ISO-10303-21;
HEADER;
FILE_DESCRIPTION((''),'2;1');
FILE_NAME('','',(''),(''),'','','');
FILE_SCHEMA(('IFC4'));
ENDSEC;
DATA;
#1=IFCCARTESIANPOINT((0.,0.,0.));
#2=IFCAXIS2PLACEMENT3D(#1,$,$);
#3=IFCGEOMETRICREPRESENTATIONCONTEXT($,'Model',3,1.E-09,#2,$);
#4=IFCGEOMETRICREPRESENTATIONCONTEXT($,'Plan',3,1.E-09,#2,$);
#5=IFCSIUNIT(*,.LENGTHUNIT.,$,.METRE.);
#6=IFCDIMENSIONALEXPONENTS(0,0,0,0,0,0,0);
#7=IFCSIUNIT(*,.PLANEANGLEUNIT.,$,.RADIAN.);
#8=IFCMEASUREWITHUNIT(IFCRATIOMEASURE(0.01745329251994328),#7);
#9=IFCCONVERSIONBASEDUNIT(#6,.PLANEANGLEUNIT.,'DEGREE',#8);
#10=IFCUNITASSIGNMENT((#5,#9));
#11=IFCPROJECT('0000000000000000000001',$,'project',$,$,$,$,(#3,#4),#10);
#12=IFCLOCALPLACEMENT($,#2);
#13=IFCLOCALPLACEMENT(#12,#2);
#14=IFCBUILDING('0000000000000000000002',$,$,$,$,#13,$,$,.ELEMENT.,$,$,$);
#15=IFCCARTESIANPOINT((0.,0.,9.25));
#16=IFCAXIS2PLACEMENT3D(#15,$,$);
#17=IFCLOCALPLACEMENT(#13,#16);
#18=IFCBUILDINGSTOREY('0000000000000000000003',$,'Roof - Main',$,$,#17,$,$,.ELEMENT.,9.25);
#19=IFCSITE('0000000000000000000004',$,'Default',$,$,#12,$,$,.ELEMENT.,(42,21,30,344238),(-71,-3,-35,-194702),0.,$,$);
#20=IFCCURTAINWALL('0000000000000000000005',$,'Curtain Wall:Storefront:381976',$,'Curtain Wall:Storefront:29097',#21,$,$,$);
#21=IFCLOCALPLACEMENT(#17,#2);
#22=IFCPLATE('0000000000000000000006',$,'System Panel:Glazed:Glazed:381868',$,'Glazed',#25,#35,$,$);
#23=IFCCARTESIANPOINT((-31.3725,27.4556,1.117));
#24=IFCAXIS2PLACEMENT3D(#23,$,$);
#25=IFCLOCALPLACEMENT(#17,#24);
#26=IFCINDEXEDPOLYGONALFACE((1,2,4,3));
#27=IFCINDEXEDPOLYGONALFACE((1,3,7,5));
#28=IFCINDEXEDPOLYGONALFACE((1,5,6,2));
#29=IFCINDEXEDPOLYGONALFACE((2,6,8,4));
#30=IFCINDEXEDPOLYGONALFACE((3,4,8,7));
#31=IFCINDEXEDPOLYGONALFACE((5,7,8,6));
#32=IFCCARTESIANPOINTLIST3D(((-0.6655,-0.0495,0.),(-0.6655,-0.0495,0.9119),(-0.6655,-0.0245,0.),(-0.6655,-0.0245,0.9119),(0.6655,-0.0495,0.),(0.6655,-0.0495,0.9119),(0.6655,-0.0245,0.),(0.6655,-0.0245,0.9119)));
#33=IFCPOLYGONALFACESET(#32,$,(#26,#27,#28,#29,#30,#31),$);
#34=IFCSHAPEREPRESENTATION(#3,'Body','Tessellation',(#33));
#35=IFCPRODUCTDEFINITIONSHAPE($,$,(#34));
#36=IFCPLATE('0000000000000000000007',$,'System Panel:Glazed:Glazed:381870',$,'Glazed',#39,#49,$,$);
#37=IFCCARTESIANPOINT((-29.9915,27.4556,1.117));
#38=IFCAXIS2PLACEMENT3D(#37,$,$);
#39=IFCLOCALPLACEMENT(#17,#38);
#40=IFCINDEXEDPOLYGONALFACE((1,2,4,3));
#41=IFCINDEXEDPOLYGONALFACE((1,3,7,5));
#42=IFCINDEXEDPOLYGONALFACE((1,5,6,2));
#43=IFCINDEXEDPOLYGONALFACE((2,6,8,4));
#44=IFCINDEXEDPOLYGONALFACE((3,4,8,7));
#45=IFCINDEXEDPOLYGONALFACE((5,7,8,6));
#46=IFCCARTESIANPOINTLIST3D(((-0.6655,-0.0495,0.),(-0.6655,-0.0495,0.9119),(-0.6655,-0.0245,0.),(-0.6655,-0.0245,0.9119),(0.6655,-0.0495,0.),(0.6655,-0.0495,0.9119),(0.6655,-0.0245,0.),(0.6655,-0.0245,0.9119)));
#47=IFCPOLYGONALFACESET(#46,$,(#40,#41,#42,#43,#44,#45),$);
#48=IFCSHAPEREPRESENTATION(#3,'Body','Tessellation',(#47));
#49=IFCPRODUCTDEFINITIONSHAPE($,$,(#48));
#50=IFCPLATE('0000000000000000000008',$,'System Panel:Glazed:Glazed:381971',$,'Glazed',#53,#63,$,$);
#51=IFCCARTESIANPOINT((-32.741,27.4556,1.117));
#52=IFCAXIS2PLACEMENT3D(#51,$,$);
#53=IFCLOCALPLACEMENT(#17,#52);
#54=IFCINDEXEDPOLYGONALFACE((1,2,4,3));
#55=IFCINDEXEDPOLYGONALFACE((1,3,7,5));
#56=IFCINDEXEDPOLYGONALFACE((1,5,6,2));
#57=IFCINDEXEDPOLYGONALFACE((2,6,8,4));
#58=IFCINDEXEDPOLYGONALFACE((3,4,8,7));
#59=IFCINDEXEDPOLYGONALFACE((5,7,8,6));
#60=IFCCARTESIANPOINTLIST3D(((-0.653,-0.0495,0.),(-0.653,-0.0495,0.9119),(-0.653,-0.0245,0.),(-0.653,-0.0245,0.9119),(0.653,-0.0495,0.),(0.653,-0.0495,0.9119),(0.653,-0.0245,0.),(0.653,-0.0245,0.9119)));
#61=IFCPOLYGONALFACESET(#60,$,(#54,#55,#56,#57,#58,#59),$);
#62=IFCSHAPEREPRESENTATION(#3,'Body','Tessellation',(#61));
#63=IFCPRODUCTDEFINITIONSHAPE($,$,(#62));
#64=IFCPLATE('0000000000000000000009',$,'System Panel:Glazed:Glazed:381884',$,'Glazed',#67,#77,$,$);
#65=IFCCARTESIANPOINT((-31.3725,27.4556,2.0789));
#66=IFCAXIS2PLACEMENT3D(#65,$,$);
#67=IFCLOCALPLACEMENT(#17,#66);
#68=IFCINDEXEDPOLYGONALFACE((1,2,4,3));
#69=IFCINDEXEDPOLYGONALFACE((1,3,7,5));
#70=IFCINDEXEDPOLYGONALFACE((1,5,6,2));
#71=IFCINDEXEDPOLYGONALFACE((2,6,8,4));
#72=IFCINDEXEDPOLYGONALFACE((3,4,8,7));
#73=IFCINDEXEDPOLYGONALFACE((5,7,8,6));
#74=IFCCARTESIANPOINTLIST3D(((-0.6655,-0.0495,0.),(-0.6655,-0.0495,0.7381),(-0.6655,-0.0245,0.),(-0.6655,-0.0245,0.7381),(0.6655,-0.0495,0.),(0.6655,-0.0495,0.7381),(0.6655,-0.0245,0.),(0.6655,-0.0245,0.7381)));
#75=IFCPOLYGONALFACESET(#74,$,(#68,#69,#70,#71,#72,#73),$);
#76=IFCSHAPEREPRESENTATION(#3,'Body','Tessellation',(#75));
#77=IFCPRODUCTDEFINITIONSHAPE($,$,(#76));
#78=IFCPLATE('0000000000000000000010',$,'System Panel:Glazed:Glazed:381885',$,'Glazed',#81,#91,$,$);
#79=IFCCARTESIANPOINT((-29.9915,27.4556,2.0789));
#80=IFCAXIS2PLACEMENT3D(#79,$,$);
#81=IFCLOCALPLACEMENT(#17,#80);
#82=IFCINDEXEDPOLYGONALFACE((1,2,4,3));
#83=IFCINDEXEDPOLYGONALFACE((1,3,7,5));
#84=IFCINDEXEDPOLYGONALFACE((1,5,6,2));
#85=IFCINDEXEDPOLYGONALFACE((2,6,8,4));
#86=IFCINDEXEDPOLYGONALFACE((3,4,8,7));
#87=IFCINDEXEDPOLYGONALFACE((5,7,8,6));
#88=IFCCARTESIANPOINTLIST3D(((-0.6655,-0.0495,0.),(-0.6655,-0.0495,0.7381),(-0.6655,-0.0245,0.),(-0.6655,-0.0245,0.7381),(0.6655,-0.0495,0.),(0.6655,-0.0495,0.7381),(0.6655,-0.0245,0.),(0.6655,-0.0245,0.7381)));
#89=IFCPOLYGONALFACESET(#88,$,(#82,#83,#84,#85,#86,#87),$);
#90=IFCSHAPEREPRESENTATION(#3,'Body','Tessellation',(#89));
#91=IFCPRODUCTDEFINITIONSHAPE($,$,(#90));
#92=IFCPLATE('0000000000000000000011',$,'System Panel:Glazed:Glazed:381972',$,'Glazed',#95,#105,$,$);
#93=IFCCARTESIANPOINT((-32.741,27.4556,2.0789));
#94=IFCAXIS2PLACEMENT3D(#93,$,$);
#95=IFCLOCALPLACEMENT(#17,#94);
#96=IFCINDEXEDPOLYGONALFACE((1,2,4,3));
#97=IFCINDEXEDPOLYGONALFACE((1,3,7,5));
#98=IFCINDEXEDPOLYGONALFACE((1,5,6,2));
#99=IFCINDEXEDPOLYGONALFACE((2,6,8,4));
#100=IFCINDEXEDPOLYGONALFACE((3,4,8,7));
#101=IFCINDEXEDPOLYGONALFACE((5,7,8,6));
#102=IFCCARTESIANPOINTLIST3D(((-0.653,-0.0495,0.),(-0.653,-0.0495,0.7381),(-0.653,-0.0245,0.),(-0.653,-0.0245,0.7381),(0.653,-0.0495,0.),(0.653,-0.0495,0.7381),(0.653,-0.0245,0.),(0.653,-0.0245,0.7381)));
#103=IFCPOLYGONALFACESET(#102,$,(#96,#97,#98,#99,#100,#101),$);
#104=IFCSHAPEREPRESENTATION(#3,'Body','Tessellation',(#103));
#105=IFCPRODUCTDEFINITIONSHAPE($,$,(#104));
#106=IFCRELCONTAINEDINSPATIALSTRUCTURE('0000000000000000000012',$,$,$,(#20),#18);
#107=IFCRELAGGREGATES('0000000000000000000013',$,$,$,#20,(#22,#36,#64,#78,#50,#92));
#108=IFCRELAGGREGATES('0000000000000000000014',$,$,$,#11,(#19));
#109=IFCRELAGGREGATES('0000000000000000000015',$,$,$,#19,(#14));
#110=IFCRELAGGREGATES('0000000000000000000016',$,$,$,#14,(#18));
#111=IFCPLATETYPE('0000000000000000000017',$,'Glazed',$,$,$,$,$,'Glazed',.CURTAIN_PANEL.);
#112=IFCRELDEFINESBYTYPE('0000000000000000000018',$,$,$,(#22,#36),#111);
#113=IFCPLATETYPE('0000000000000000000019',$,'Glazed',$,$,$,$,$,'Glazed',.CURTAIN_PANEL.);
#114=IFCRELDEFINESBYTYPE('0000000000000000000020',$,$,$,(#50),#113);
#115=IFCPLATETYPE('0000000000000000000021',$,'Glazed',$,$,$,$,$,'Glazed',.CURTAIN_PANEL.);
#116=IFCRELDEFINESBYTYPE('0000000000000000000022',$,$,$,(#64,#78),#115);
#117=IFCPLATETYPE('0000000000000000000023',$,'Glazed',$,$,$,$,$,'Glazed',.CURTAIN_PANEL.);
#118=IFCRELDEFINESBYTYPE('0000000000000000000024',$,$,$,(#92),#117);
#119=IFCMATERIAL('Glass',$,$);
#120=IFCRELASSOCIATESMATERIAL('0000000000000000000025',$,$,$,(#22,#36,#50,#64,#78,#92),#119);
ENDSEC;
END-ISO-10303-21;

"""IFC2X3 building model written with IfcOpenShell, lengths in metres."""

from ifc_helpers import new_model, entity, si_unit, converted_unit, frame, origin, origin_2d_with_axis, place, context, project, spatial, rectangle, extrude, source, transform, mapped, material, type_object, type_shapes, element, aggregate, save


model = new_model("IFC2X3")

# Units and contexts
model_context = context("Model", 3, precision=1e-09, world=origin())
plan_context = context("Plan", 3, precision=1e-09, world=origin())
ifc_project = project(units=[si_unit("LENGTHUNIT", "METRE"), converted_unit("PLANEANGLEUNIT", "DEGREE", entity("IfcRatioMeasure", 0.01745329251994328), si_unit("PLANEANGLEUNIT", "RADIAN"), dimensions=[0, 0, 0, 0, 0, 0, 0])], contexts=[model_context, plan_context])

# Site, building, storey
site_placement = place(None, origin())
site = spatial("IfcSite", under=ifc_project, at=site_placement, Name="Default", CompositionType="ELEMENT", RefLatitude=(42, 21, 30, 344238), RefLongitude=(-71, -3, -35, -194702), RefElevation=0.0)
building_placement = place(site_placement, origin())
building = spatial("IfcBuilding", under=site, at=building_placement, CompositionType="ELEMENT")
storey_placement = place(building_placement, frame((0.0, 0.0, 9.25)))
storey = spatial("IfcBuildingStorey", under=building, at=storey_placement, Name="Roof - Main", CompositionType="ELEMENT", Elevation=9.25)

# Curtain wall
curtain_wall_1_placement = place(storey_placement, origin())
curtain_wall_1 = element("IfcCurtainWall", 1, at=curtain_wall_1_placement, inside=storey, Name="Curtain Wall:Storefront:381976", ObjectType="Curtain Wall:Storefront:29097")

# Plates
ifc_material_1 = material(Name="Glass")
plate_type_1 = type_object("IfcPlateType", Name="Glazed", ElementType="Glazed", PredefinedType="CURTAIN_PANEL")
shared_shape_1 = source(origin(), model_context, "Body", "SweptSolid", [
    extrude(rectangle(XDim=0.025, YDim=1.331, at=origin_2d_with_axis()), frame((0.0, -0.037, 0.0), z_axis=(0.0, 0.0, 1.0), x_axis=(0.0, 1.0, 0.0)), (0.0, 0.0, 1.0), 0.9119),
])
type_shapes(plate_type_1, [shared_shape_1])
plate_1_placement = place(storey_placement, frame((-31.3725, 27.4556, 1.117)))
plate_1 = element("IfcPlate", 2, at=plate_1_placement, type_object=plate_type_1, material=ifc_material_1, Name="System Panel:Glazed:Glazed:381868", ObjectType="Glazed", context=model_context, shape_type="MappedRepresentation", body=[
    mapped(shared_shape_1, transform((0.0, 0.0, 0.0), scale=1.0)),
])
plate_2_placement = place(storey_placement, frame((-29.9915, 27.4556, 1.117)))
plate_2 = element("IfcPlate", 3, at=plate_2_placement, type_object=plate_type_1, material=ifc_material_1, Name="System Panel:Glazed:Glazed:381870", ObjectType="Glazed", context=model_context, shape_type="MappedRepresentation", body=[
    mapped(shared_shape_1, transform((0.0, 0.0, 0.0), scale=1.0)),
])
plate_type_2 = type_object("IfcPlateType", Name="Glazed", ElementType="Glazed", PredefinedType="CURTAIN_PANEL")
shared_shape_2 = source(origin(), model_context, "Body", "SweptSolid", [
    extrude(rectangle(XDim=0.025, YDim=1.306, at=origin_2d_with_axis()), frame((0.0, -0.037, 0.0), z_axis=(0.0, 0.0, 1.0), x_axis=(0.0, 1.0, 0.0)), (0.0, 0.0, 1.0), 0.9119),
])
type_shapes(plate_type_2, [shared_shape_2])
plate_3_placement = place(storey_placement, frame((-32.741, 27.4556, 1.117)))
plate_3 = element("IfcPlate", 4, at=plate_3_placement, type_object=plate_type_2, material=ifc_material_1, Name="System Panel:Glazed:Glazed:381971", ObjectType="Glazed", context=model_context, shape_type="MappedRepresentation", body=[
    mapped(shared_shape_2, transform((0.0, 0.0, 0.0), scale=1.0)),
])
plate_type_3 = type_object("IfcPlateType", Name="Glazed", ElementType="Glazed", PredefinedType="CURTAIN_PANEL")
shared_shape_3 = source(origin(), model_context, "Body", "SweptSolid", [
    extrude(rectangle(XDim=0.025, YDim=1.331, at=origin_2d_with_axis()), frame((0.0, -0.037, 0.0), z_axis=(0.0, 0.0, 1.0), x_axis=(0.0, 1.0, 0.0)), (0.0, 0.0, 1.0), 0.7381),
])
type_shapes(plate_type_3, [shared_shape_3])
plate_4_placement = place(storey_placement, frame((-31.3725, 27.4556, 2.0789)))
plate_4 = element("IfcPlate", 5, at=plate_4_placement, type_object=plate_type_3, material=ifc_material_1, Name="System Panel:Glazed:Glazed:381884", ObjectType="Glazed", context=model_context, shape_type="MappedRepresentation", body=[
    mapped(shared_shape_3, transform((0.0, 0.0, 0.0), scale=1.0)),
])
plate_5_placement = place(storey_placement, frame((-29.9915, 27.4556, 2.0789)))
plate_5 = element("IfcPlate", 6, at=plate_5_placement, type_object=plate_type_3, material=ifc_material_1, Name="System Panel:Glazed:Glazed:381885", ObjectType="Glazed", context=model_context, shape_type="MappedRepresentation", body=[
    mapped(shared_shape_3, transform((0.0, 0.0, 0.0), scale=1.0)),
])
plate_type_4 = type_object("IfcPlateType", Name="Glazed", ElementType="Glazed", PredefinedType="CURTAIN_PANEL")
shared_shape_4 = source(origin(), model_context, "Body", "SweptSolid", [
    extrude(rectangle(XDim=0.025, YDim=1.306, at=origin_2d_with_axis()), frame((0.0, -0.037, 0.0), z_axis=(0.0, 0.0, 1.0), x_axis=(0.0, 1.0, 0.0)), (0.0, 0.0, 1.0), 0.7381),
])
type_shapes(plate_type_4, [shared_shape_4])
plate_6_placement = place(storey_placement, frame((-32.741, 27.4556, 2.0789)))
plate_6 = element("IfcPlate", 7, at=plate_6_placement, type_object=plate_type_4, material=ifc_material_1, Name="System Panel:Glazed:Glazed:381972", ObjectType="Glazed", context=model_context, shape_type="MappedRepresentation", body=[
    mapped(shared_shape_4, transform((0.0, 0.0, 0.0), scale=1.0)),
])
aggregate(curtain_wall_1, [plate_1, plate_2, plate_4, plate_5, plate_3, plate_6])

save(model, "model.ifc")
